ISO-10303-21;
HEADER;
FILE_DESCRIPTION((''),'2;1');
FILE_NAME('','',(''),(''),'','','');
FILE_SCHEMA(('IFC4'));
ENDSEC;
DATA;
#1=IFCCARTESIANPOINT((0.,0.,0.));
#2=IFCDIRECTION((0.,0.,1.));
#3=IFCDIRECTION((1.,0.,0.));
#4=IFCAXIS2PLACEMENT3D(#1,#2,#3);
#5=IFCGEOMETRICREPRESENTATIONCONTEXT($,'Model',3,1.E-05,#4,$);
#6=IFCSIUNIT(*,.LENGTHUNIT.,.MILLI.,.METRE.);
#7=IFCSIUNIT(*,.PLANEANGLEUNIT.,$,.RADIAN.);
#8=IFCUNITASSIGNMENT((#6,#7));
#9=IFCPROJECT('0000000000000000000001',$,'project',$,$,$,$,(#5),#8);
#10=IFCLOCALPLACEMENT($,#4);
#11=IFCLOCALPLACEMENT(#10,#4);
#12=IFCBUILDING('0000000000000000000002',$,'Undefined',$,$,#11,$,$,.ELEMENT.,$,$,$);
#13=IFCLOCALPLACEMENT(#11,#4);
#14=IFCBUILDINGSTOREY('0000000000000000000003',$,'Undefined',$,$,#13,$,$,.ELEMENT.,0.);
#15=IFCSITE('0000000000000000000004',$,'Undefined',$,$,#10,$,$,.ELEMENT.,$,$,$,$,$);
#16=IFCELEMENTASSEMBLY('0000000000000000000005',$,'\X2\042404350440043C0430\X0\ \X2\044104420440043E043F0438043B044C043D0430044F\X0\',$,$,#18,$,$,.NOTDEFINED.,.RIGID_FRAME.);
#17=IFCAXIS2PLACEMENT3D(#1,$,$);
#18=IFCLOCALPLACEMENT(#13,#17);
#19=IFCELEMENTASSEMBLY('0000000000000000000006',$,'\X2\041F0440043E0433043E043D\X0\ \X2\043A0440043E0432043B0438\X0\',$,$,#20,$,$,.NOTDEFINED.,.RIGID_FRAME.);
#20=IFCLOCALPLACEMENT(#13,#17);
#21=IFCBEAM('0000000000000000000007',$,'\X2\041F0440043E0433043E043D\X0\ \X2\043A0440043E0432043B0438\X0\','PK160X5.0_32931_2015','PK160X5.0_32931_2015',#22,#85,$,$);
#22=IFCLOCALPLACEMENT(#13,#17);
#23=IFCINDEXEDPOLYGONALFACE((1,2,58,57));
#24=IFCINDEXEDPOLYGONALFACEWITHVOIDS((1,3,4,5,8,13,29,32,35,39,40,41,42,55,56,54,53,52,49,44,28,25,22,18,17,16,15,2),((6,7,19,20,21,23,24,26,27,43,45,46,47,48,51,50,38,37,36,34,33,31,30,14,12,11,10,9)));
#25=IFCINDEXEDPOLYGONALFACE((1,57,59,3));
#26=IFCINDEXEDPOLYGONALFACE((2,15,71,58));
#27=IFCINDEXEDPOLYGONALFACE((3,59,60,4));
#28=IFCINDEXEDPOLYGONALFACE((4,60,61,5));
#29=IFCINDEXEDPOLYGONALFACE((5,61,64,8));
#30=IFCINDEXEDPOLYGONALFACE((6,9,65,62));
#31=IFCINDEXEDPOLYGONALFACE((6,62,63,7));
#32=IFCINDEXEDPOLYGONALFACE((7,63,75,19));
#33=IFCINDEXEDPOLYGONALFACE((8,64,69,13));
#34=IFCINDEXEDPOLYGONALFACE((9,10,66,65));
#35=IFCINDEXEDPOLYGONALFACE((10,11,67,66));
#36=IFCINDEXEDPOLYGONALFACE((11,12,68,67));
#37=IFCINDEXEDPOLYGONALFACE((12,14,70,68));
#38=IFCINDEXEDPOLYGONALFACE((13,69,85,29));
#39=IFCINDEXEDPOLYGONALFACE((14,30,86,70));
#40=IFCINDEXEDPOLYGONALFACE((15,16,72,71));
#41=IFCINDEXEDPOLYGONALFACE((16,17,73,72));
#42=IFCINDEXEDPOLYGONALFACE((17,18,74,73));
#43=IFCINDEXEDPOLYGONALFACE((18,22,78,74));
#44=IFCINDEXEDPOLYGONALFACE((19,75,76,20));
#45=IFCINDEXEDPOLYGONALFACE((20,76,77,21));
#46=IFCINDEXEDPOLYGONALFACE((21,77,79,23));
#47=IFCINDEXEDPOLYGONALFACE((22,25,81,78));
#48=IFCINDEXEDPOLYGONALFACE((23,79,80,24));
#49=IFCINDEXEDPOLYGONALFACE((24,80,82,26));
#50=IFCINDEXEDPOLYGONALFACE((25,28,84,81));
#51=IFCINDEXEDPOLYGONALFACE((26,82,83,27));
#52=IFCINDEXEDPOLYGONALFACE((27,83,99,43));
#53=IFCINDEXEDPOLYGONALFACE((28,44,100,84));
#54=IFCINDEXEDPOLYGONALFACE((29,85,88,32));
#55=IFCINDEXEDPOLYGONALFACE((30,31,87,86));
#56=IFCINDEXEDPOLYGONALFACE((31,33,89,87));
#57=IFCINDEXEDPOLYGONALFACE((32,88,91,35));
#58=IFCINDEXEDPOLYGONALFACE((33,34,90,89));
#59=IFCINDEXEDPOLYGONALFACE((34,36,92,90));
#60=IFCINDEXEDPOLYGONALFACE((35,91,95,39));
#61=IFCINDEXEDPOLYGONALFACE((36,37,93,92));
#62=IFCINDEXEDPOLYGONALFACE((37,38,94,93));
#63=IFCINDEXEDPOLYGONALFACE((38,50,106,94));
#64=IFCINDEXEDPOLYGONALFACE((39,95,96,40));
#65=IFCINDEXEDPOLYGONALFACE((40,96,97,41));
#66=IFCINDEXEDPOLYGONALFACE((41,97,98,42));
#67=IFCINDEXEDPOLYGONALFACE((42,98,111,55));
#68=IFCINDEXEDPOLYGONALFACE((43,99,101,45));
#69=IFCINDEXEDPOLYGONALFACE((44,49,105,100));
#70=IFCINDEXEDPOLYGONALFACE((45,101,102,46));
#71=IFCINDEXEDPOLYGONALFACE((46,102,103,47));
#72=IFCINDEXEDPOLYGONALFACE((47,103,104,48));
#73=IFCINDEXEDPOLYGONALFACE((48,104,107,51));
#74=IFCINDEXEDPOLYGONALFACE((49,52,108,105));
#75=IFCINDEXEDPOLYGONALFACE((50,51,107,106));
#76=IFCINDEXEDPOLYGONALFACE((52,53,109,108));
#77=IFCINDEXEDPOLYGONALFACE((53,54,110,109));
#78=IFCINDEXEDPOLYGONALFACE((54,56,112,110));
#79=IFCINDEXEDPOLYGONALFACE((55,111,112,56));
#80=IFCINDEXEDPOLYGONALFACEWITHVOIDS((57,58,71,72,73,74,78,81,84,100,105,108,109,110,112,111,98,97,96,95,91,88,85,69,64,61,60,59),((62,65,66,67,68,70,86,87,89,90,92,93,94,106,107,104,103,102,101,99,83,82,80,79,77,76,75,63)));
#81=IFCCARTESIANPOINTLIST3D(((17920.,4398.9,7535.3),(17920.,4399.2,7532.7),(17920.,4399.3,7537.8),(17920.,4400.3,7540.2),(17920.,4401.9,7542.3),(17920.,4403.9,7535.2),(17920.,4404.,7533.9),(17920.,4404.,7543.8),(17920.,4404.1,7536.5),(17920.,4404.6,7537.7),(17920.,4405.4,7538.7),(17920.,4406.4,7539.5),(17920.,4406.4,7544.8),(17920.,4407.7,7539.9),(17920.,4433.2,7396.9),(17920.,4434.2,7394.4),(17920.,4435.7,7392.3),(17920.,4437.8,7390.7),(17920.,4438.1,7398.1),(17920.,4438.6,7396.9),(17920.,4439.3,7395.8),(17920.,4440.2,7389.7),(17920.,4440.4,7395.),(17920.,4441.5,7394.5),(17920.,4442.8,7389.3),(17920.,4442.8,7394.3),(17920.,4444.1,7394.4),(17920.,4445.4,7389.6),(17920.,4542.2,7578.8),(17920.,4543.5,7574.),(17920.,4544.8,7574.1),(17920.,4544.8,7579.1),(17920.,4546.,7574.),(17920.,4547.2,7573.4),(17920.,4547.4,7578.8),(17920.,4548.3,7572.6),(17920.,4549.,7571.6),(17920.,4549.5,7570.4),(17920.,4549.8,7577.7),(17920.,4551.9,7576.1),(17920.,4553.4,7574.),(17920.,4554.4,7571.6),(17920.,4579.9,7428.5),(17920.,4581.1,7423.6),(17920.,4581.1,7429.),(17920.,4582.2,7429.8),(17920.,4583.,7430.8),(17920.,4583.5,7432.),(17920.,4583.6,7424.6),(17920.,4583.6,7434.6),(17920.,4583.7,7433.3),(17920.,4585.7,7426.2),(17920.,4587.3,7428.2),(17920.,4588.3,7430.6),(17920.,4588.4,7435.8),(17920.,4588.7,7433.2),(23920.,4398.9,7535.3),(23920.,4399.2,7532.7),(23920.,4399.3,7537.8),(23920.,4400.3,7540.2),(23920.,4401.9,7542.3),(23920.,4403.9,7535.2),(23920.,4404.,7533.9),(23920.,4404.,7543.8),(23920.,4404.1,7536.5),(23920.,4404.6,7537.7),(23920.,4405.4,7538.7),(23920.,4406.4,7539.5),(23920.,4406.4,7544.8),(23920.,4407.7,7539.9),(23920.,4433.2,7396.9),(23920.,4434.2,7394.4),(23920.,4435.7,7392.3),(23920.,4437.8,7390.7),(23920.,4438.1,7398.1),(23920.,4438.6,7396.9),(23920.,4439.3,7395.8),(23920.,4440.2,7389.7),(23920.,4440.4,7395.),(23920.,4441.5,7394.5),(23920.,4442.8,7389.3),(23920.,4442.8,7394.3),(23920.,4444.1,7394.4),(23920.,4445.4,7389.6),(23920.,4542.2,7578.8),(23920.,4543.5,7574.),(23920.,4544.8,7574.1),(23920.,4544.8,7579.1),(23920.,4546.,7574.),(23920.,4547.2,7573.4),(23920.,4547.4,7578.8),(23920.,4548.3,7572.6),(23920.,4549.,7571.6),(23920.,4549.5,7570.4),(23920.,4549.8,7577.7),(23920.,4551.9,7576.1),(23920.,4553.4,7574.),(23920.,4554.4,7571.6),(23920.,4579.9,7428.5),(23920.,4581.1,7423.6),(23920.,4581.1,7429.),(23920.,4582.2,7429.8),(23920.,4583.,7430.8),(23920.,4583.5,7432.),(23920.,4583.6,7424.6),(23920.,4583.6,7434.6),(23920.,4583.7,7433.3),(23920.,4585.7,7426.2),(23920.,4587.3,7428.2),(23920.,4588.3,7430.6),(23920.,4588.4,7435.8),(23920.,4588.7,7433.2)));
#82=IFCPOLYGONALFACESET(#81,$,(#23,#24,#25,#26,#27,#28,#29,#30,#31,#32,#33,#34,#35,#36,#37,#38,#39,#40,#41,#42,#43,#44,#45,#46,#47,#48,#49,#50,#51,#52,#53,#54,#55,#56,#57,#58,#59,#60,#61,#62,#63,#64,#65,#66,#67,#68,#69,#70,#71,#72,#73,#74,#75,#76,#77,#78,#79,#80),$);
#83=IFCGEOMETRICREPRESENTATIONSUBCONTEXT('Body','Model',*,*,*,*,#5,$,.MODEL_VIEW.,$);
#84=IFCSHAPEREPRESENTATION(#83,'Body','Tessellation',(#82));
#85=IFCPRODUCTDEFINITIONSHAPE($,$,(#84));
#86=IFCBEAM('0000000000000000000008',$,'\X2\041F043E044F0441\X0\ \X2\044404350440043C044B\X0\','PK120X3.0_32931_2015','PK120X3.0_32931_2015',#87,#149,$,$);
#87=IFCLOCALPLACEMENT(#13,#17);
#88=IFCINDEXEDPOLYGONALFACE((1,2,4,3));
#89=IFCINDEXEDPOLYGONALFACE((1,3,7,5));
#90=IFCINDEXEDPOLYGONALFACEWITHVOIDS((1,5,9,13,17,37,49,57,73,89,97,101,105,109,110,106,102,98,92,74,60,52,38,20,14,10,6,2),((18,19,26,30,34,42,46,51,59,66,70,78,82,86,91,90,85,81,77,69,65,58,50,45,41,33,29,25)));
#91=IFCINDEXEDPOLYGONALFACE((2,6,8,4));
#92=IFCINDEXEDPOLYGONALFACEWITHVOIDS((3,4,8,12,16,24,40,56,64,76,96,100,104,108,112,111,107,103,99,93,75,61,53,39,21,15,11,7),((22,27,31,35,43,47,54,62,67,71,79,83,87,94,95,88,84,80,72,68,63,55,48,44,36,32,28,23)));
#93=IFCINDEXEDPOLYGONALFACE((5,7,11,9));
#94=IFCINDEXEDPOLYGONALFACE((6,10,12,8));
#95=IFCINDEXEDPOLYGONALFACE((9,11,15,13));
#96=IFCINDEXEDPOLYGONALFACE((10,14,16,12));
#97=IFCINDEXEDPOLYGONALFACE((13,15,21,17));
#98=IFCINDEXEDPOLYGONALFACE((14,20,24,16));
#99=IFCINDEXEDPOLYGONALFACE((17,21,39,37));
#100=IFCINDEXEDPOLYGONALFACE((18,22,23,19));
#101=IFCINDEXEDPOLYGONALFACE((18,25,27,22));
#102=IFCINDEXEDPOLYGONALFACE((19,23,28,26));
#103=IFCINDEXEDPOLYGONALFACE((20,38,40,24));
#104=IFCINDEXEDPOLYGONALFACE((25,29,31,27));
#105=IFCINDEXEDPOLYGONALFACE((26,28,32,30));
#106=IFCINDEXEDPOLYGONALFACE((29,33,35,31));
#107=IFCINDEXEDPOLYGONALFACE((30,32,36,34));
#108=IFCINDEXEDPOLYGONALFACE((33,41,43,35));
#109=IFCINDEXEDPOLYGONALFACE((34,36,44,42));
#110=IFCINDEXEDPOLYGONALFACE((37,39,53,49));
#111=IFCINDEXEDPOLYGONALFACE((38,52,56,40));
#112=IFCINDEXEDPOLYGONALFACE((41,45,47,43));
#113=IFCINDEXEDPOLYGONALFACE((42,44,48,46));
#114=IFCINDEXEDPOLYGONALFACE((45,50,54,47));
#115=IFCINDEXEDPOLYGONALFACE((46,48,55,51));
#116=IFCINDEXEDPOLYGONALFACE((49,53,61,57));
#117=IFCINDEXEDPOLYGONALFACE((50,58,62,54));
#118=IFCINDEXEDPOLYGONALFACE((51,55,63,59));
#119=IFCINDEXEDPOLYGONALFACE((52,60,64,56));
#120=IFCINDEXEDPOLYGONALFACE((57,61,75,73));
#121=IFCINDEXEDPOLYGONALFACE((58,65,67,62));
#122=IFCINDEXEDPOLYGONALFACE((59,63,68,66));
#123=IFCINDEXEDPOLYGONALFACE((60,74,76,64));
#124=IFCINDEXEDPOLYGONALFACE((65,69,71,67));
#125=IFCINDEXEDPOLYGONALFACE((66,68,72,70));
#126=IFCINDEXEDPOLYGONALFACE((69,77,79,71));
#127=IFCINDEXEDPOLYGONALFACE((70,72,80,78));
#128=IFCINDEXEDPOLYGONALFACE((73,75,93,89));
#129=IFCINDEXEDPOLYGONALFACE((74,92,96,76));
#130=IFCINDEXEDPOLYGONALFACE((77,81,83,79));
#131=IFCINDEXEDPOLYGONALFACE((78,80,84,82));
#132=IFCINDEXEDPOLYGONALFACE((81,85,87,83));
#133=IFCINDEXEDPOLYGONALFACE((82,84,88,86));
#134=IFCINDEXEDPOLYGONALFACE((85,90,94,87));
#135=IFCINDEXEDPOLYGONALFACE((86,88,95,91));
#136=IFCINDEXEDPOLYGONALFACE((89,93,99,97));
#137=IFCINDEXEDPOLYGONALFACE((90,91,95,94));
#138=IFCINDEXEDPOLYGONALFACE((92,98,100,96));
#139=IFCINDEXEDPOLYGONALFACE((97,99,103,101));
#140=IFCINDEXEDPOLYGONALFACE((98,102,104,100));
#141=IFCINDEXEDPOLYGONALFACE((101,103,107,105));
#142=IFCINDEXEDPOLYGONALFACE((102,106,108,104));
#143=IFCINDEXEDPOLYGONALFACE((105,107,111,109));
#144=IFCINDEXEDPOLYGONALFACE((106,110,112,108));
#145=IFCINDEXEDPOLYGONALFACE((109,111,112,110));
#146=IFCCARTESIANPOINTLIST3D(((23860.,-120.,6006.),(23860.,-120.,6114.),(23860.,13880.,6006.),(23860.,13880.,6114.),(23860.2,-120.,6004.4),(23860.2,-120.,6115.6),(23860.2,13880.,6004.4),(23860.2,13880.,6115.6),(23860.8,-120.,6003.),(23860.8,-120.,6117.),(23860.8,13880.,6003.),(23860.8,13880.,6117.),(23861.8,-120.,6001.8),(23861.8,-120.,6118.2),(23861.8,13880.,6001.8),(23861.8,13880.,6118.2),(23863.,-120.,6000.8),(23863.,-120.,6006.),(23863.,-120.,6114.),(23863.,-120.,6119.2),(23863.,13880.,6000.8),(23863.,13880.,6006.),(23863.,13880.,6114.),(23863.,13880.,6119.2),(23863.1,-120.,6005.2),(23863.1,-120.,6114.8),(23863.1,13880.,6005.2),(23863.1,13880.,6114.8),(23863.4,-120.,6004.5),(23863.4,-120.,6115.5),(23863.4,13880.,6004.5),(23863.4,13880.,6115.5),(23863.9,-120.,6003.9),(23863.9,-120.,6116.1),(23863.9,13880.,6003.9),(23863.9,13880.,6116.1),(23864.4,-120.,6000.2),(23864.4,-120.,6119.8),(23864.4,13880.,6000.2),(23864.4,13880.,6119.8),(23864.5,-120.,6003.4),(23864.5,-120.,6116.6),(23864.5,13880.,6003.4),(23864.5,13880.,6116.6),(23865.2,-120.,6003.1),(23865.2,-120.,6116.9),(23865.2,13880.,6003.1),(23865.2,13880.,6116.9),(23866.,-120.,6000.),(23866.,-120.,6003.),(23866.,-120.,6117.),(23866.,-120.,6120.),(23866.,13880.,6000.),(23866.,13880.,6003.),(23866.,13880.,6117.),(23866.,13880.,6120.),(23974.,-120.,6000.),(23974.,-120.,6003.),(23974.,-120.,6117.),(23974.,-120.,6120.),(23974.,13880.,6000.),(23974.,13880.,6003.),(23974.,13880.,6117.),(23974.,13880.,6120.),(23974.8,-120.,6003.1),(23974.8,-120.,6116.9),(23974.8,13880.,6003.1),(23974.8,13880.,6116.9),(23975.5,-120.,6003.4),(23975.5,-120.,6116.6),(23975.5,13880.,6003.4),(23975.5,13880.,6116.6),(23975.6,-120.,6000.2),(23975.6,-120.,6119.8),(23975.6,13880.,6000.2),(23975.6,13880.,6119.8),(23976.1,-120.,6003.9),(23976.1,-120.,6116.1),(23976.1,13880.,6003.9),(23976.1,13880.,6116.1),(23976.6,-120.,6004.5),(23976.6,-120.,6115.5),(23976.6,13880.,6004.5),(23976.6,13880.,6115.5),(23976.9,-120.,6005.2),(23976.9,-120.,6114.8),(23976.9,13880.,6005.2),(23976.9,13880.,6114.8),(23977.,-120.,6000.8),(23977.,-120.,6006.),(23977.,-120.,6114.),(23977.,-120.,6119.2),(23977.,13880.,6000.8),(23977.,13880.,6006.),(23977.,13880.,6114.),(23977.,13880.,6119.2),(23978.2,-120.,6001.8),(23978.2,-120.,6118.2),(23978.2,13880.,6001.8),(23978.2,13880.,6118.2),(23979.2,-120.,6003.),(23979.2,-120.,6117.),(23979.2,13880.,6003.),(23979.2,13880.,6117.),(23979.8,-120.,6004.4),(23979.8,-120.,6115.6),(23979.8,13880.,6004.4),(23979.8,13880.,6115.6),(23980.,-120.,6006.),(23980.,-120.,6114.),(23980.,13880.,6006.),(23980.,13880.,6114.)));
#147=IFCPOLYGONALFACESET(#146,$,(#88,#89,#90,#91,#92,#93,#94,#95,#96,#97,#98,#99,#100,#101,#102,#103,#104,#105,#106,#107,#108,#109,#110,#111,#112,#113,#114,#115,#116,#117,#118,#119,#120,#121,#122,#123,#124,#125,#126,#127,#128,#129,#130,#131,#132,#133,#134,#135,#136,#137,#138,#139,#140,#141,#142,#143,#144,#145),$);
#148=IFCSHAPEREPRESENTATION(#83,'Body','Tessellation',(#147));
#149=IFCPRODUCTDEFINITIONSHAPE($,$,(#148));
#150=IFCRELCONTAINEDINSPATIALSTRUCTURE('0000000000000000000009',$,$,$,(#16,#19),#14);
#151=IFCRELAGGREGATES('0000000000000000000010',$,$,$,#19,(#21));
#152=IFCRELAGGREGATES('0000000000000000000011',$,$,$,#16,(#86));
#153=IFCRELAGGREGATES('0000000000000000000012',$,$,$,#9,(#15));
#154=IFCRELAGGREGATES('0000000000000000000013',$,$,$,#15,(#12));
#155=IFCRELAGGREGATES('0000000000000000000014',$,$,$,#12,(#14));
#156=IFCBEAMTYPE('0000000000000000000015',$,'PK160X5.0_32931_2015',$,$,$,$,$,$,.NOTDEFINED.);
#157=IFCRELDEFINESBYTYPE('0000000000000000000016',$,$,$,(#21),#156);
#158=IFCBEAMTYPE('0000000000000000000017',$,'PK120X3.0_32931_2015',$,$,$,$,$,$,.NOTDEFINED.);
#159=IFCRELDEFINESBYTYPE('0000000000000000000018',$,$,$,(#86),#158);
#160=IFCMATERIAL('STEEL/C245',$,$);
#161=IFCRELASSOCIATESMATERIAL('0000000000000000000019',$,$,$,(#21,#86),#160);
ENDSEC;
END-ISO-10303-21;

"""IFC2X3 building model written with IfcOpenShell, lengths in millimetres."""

from ifc_helpers import new_model, si_unit, frame, origin_with_axes, origin_2d_with_axis, place, context, subcontext, project, spatial, hollow_rectangle, extrude, material, type_object, element, aggregate, save


model = new_model("IFC2X3")

# Units and contexts
model_context = context("Model", 3, precision=1e-05, world=origin_with_axes())
body_context = subcontext(model_context, "Body", "Model", "MODEL_VIEW")
ifc_project = project(units=[si_unit("LENGTHUNIT", "METRE", prefix="MILLI"), si_unit("PLANEANGLEUNIT", "RADIAN")], contexts=[model_context])

# Site, building, storey
site_placement = place(None, origin_with_axes())
site = spatial("IfcSite", under=ifc_project, at=site_placement, Name="Undefined", CompositionType="ELEMENT")
building_placement = place(site_placement, origin_with_axes())
building = spatial("IfcBuilding", under=site, at=building_placement, Name="Undefined", CompositionType="ELEMENT")
storey_placement = place(building_placement, origin_with_axes())
storey = spatial("IfcBuildingStorey", under=building, at=storey_placement, Name="Undefined", CompositionType="ELEMENT", Elevation=0.0)

# Shared definitions
ifc_material = material(Name="STEEL/C245")

# Element assembly
assembly_1_placement = place(storey_placement, origin_with_axes())
assembly_1 = element("IfcElementAssembly", 1, at=assembly_1_placement, inside=storey, Name="Ферма стропильная", AssemblyPlace="NOTDEFINED", PredefinedType="RIGID_FRAME")

# Element assembly, beam
beam_type_1 = type_object("IfcBeamType", Name="PK160X5.0_32931_2015", PredefinedType="NOTDEFINED")
assembly_2_placement = place(storey_placement, origin_with_axes())
assembly_2 = element("IfcElementAssembly", 2, at=assembly_2_placement, inside=storey, Name="Прогон кровли", AssemblyPlace="NOTDEFINED", PredefinedType="RIGID_FRAME")
beam_1_placement = place(assembly_2_placement, frame((17920.0, 4493.8, 7484.2), z_axis=(0.0, -0.243188, 0.969979), x_axis=(1.0, 0.0, 0.0)))
beam_1 = element("IfcBeam", 3, at=beam_1_placement, type_object=beam_type_1, material=ifc_material, Name="Прогон кровли", Description="PK160X5.0_32931_2015", ObjectType="PK160X5.0_32931_2015", context=body_context, shape_type="SweptSolid", body=[
    extrude(hollow_rectangle(XDim=160.0, YDim=160.0, WallThickness=5.0, InnerFilletRadius=5.0, OuterFilletRadius=10.0, at=origin_2d_with_axis()), frame((6000.0, 0.0, 0.0), z_axis=(-1.0, 0.0, 0.0), x_axis=(0.0, -1.0, 0.0)), (0.0, 0.0, 1.0), 6000.0),
])
aggregate(assembly_2, [beam_1])

# Beam
beam_type_2 = type_object("IfcBeamType", Name="PK120X3.0_32931_2015", PredefinedType="NOTDEFINED")
beam_2_placement = place(assembly_1_placement, frame((23920.0, -120.0, 6060.0), z_axis=(0.0, 0.0, 1.0), x_axis=(0.0, 1.0, 0.0)))
beam_2 = element("IfcBeam", 4, at=beam_2_placement, type_object=beam_type_2, material=ifc_material, Name="Пояс фермы", Description="PK120X3.0_32931_2015", ObjectType="PK120X3.0_32931_2015", context=body_context, shape_type="SweptSolid", body=[
    extrude(hollow_rectangle(XDim=120.0, YDim=120.0, WallThickness=3.0, InnerFilletRadius=3.0, OuterFilletRadius=6.0, at=origin_2d_with_axis()), frame((14000.0, 0.0, 0.0), z_axis=(-1.0, 0.0, 0.0), x_axis=(0.0, -1.0, 0.0)), (0.0, 0.0, 1.0), 14000.0),
])
aggregate(assembly_1, [beam_2])

save(model, "model.ifc")
